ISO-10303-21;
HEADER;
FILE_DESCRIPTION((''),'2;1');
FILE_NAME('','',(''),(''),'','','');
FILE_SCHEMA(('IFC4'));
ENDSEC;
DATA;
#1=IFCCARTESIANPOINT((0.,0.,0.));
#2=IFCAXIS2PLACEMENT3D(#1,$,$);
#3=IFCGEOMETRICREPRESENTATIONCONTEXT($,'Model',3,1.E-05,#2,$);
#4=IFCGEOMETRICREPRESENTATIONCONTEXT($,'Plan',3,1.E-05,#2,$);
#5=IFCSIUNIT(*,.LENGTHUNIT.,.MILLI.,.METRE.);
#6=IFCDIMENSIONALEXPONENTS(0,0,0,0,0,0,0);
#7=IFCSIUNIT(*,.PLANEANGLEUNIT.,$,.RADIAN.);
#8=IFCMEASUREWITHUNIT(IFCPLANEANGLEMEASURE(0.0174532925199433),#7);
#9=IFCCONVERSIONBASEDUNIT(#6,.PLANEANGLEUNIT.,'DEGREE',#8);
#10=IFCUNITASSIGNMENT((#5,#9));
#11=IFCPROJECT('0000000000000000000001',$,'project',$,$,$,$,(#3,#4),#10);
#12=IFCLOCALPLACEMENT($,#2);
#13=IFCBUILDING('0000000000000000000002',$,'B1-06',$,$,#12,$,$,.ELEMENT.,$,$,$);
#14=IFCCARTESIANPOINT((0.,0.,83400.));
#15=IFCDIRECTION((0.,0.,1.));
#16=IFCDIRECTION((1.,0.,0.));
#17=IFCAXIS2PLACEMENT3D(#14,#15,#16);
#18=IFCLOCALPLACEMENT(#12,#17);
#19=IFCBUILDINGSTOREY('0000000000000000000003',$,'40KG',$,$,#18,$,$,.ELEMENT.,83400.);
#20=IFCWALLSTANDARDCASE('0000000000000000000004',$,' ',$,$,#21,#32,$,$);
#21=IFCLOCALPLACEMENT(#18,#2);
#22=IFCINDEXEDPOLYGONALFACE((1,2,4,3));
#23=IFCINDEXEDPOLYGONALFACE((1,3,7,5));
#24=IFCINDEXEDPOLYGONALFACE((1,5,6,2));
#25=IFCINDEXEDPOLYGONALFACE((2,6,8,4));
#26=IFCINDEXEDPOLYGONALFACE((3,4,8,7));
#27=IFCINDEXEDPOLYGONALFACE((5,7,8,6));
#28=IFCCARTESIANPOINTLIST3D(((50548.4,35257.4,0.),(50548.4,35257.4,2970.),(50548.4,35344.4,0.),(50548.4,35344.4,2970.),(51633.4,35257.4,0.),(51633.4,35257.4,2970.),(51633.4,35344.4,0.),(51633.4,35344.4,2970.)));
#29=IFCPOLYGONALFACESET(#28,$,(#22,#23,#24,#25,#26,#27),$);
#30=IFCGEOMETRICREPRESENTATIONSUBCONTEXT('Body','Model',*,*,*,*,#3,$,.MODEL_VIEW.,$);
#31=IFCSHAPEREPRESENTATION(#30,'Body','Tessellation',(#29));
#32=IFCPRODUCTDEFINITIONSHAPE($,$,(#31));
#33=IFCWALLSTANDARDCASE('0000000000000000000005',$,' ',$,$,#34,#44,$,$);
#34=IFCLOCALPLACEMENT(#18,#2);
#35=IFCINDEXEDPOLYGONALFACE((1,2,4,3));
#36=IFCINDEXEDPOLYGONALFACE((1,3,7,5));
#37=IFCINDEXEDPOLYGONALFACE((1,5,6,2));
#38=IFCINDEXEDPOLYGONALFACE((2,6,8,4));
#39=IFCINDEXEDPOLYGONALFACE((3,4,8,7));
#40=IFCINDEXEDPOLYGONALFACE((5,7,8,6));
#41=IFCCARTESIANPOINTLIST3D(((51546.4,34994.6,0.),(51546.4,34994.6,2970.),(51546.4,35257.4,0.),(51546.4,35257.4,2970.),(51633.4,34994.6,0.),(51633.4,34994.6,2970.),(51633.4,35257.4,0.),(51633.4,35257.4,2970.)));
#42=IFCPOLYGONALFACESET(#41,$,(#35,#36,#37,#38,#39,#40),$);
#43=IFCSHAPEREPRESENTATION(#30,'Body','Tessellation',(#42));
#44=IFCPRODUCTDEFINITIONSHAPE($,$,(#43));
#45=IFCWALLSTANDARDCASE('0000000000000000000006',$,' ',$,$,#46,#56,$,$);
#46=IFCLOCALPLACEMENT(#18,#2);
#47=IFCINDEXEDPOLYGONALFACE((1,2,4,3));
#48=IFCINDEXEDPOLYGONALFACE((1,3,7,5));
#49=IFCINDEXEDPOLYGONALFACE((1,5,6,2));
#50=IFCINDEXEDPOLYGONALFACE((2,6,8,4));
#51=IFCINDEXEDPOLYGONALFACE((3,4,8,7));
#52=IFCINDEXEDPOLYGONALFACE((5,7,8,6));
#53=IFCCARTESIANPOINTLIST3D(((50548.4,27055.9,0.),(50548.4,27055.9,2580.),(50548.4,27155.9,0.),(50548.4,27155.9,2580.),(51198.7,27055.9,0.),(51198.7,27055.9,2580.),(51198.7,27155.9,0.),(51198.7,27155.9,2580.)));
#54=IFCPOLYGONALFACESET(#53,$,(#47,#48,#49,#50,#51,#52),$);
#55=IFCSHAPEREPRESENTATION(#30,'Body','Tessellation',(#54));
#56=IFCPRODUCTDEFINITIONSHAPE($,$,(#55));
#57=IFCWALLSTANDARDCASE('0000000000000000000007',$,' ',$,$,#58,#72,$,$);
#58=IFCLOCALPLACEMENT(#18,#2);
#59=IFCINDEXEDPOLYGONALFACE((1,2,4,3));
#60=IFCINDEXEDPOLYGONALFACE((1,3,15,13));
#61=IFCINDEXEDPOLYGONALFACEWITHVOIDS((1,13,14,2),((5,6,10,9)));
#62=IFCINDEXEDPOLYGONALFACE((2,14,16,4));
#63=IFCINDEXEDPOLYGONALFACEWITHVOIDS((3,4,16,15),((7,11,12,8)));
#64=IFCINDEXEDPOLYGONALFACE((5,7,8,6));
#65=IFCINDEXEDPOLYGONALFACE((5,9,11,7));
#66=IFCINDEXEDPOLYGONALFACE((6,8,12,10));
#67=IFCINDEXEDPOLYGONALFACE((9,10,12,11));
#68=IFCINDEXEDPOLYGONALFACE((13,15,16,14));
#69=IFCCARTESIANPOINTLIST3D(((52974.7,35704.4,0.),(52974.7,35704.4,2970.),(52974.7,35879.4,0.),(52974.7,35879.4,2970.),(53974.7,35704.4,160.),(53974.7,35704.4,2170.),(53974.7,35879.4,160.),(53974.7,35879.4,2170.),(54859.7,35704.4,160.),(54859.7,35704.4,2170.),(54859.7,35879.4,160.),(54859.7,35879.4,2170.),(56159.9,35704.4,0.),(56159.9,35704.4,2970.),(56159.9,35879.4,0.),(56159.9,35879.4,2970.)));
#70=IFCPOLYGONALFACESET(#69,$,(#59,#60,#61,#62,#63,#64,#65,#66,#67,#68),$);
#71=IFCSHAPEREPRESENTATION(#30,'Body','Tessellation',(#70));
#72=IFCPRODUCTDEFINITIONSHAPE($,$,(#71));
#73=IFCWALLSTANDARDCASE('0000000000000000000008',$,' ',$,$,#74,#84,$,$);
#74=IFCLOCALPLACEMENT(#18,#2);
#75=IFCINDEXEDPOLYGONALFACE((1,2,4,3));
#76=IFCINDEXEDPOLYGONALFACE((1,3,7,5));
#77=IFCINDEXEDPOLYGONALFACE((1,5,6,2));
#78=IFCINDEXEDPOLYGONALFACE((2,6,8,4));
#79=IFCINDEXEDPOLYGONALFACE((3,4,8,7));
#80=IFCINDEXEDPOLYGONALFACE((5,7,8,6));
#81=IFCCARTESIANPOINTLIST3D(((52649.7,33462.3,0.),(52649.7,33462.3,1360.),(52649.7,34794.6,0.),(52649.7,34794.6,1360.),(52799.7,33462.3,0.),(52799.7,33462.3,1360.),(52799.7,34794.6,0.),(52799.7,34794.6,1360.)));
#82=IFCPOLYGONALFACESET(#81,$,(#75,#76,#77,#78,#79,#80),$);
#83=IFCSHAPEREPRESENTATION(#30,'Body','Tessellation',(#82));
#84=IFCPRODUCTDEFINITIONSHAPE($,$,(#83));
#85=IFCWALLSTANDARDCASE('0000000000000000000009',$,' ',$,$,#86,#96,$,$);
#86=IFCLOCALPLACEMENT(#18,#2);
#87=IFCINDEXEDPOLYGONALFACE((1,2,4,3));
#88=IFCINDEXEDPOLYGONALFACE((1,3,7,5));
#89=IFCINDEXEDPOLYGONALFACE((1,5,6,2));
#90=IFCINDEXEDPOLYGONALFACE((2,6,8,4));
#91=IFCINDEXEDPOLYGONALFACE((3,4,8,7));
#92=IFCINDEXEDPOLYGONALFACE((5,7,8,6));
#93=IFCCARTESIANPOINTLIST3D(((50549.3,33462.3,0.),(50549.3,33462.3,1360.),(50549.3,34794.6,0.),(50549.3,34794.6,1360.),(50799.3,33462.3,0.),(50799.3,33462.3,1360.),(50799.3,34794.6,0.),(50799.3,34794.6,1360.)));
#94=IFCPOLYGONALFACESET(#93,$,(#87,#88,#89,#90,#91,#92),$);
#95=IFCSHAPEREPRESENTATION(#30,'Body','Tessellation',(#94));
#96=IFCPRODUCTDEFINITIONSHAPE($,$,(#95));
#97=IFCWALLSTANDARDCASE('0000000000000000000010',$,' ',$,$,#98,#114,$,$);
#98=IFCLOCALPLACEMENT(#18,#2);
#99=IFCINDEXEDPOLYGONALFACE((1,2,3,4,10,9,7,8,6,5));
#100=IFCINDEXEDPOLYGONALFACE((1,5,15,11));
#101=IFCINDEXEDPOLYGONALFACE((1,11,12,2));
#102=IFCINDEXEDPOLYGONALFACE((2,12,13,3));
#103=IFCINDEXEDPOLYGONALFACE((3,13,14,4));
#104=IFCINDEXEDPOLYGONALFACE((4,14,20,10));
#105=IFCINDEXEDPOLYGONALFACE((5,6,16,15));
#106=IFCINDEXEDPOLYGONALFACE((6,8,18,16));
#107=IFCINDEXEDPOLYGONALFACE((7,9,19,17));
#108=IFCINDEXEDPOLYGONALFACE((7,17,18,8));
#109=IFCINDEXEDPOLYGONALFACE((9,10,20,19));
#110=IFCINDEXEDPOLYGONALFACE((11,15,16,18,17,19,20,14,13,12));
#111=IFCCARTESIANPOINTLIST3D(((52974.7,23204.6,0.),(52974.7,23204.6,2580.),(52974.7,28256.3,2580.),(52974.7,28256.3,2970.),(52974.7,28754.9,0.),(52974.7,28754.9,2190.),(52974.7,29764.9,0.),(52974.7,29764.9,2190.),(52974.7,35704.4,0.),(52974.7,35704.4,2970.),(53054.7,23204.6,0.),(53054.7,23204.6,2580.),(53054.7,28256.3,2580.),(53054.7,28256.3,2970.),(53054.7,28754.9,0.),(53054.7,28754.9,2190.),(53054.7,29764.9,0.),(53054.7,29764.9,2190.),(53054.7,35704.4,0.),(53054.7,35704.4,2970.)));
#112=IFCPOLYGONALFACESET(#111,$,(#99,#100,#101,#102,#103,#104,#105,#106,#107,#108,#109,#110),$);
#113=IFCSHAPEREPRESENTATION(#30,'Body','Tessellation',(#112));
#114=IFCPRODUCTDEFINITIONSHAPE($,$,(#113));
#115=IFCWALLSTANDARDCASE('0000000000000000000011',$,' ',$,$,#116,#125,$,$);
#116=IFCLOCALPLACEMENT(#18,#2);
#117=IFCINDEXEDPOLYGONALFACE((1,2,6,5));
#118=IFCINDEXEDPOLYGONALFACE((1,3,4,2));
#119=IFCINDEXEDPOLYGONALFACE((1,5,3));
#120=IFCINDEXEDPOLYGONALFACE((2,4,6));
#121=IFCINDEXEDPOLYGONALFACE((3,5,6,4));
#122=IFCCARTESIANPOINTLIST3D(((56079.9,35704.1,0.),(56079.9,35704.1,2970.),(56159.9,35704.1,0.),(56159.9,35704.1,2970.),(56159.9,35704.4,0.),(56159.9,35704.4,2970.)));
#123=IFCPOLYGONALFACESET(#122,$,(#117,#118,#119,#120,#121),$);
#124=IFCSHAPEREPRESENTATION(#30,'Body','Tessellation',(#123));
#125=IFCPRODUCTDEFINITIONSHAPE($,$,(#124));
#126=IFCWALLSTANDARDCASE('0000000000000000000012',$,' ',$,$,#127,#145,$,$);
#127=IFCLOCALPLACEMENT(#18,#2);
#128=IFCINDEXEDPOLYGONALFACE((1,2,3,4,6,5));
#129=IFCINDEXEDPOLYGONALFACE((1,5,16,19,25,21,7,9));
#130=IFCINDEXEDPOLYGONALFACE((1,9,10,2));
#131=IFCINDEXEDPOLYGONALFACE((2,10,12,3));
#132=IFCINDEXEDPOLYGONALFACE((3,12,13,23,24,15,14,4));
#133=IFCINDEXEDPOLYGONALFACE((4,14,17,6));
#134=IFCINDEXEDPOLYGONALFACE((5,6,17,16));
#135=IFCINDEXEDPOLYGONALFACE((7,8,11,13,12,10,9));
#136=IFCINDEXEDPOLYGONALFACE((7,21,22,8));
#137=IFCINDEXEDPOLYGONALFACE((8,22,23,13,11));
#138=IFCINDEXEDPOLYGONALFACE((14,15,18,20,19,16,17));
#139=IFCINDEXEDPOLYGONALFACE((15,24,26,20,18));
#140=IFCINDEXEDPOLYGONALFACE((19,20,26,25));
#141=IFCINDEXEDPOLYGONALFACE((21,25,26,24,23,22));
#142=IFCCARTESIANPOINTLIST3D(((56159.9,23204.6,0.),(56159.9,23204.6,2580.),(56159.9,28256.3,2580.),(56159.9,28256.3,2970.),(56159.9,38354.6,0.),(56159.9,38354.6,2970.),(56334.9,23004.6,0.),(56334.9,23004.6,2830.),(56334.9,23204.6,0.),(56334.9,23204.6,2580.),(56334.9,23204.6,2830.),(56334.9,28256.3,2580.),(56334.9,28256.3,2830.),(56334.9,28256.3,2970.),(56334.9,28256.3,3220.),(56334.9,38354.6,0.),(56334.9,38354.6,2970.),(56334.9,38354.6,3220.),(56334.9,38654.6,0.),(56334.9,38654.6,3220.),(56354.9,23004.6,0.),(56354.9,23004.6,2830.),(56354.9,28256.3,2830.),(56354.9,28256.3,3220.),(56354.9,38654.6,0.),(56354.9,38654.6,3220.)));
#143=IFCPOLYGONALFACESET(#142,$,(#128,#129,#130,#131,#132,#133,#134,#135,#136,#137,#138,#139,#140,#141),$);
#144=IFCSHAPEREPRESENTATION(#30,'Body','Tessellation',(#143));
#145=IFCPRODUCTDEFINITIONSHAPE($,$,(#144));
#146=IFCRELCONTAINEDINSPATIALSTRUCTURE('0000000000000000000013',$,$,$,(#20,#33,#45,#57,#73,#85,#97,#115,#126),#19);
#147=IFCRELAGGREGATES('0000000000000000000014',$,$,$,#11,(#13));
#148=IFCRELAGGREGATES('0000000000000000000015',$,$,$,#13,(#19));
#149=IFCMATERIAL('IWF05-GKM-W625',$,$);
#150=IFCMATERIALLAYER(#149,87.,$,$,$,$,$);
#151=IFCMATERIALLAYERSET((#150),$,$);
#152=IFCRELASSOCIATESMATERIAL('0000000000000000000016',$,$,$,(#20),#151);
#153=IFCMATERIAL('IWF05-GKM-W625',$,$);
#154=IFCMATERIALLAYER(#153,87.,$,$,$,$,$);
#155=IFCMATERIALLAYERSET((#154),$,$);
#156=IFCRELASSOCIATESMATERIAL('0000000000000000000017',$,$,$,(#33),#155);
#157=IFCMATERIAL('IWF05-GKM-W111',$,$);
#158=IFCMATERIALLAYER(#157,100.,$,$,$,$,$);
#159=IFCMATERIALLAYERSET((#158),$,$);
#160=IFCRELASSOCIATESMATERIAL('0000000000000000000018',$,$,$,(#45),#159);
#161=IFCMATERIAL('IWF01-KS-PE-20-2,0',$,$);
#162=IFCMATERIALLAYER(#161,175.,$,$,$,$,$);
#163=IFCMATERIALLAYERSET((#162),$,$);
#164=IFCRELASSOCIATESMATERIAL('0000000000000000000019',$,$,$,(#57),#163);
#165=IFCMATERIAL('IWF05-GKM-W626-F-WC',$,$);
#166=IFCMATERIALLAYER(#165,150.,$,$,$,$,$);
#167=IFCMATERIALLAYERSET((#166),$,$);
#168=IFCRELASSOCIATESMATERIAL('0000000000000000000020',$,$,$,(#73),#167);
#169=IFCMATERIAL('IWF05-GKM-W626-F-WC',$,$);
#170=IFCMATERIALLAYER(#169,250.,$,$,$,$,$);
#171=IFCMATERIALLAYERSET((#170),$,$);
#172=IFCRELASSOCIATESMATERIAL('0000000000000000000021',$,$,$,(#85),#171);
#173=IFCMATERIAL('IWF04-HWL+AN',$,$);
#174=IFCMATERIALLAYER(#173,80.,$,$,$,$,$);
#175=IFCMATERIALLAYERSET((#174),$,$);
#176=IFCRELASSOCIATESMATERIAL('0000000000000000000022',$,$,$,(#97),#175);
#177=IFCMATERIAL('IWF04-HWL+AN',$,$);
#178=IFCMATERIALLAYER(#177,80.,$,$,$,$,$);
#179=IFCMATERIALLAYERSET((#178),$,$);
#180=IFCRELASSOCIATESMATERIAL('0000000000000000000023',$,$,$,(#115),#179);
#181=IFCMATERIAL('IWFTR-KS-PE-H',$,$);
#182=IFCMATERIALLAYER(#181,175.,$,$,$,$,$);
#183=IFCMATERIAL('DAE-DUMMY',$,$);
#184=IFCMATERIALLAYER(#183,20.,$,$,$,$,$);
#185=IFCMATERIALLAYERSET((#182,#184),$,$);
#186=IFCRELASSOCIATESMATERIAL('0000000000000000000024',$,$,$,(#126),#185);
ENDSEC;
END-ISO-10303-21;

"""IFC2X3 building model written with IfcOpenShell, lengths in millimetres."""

from ifc_helpers import new_model, entity, si_unit, converted_unit, frame, frame_2d, origin, origin_with_axes, place, context, subcontext, project, spatial, polyline, rectangle, outline, extrude, clip, bounded_halfspace, material, layer, layer_set, layer_usage, element, save


model = new_model("IFC2X3")

# Units and contexts
model_context = context("Model", 3, precision=1e-05, world=origin())
plan_context = context("Plan", 3, precision=1e-05, world=origin())
body_context = subcontext(model_context, "Body", "Model", "MODEL_VIEW")
ifc_project = project(units=[si_unit("LENGTHUNIT", "METRE", prefix="MILLI"), converted_unit("PLANEANGLEUNIT", "DEGREE", entity("IfcPlaneAngleMeasure", 0.0174532925199433), si_unit("PLANEANGLEUNIT", "RADIAN"), dimensions=[0, 0, 0, 0, 0, 0, 0])], contexts=[model_context, plan_context])

# Building, storey
building_placement = place(None, origin())
building = spatial("IfcBuilding", under=ifc_project, at=building_placement, Name="B1-06", CompositionType="ELEMENT")
storey_placement = place(building_placement, frame((0.0, 0.0, 83400.0), z_axis=(0.0, 0.0, 1.0), x_axis=(1.0, 0.0, 0.0)))
storey = spatial("IfcBuildingStorey", under=building, at=storey_placement, Name="40KG", CompositionType="ELEMENT", Elevation=83400.0)

# Walls
ifc_material_1 = material(Name="IWF05-GKM-W625")
ifc_layer_1 = layer(ifc_material_1, 87.0)
ifc_layer_set_1 = layer_set([ifc_layer_1])
ifc_layer_usage_1 = layer_usage(ifc_layer_set_1, "AXIS2", "POSITIVE", 0.0)
wall_1_placement = place(storey_placement, frame((51633.4, 35344.4, 0.0), z_axis=(0.0, 0.0, 1.0), x_axis=(-1.0, 0.0, 0.0)))
element("IfcWallStandardCase", 1, at=wall_1_placement, inside=storey, material=ifc_layer_usage_1, Name=" ", context=body_context, shape_type="SweptSolid", body=[
    extrude(rectangle(XDim=1085.0, YDim=87.0, at=frame_2d((542.5, 43.5), x_axis=(1.0, 0.0))), origin_with_axes(), (0.0, 0.0, 1.0), 2970.0),
])
ifc_material_2 = material(Name="IWF05-GKM-W625")
ifc_layer_2 = layer(ifc_material_2, 87.0)
ifc_layer_set_2 = layer_set([ifc_layer_2])
ifc_layer_usage_2 = layer_usage(ifc_layer_set_2, "AXIS2", "POSITIVE", 0.0)
wall_2_placement = place(storey_placement, frame((51633.4, 34994.6, 0.0), z_axis=(0.0, 0.0, 1.0), x_axis=(0.0, 1.0, 0.0)))
element("IfcWallStandardCase", 2, at=wall_2_placement, inside=storey, material=ifc_layer_usage_2, Name=" ", context=body_context, shape_type="SweptSolid", body=[
    extrude(rectangle(XDim=262.8, YDim=87.0, at=frame_2d((131.4, 43.5), x_axis=(1.0, 0.0))), origin_with_axes(), (0.0, 0.0, 1.0), 2970.0),
])
ifc_material_3 = material(Name="IWF05-GKM-W111")
ifc_layer_3 = layer(ifc_material_3, 100.0)
ifc_layer_set_3 = layer_set([ifc_layer_3])
ifc_layer_usage_3 = layer_usage(ifc_layer_set_3, "AXIS2", "POSITIVE", 0.0)
wall_3_placement = place(storey_placement, frame((51198.7, 27155.9, 0.0), z_axis=(0.0, 0.0, 1.0), x_axis=(-1.0, 0.0, 0.0)))
element("IfcWallStandardCase", 3, at=wall_3_placement, inside=storey, material=ifc_layer_usage_3, Name=" ", context=body_context, shape_type="SweptSolid", body=[
    extrude(rectangle(XDim=650.3, YDim=100.0, at=frame_2d((325.2, 50.0), x_axis=(1.0, 0.0))), origin_with_axes(), (0.0, 0.0, 1.0), 2580.0),
])

# Wall, opening
ifc_material_4 = material(Name="IWF01-KS-PE-20-2,0")
ifc_layer_4 = layer(ifc_material_4, 175.0)
ifc_layer_set_4 = layer_set([ifc_layer_4])
ifc_layer_usage_4 = layer_usage(ifc_layer_set_4, "AXIS2", "POSITIVE", 0.0)
wall_4_placement = place(storey_placement, frame((56159.9, 35879.4, 0.0), z_axis=(0.0, 0.0, 1.0), x_axis=(-1.0, 0.0, 0.0)))
wall_4 = element("IfcWallStandardCase", 4, at=wall_4_placement, inside=storey, material=ifc_layer_usage_4, Name=" ", context=body_context, shape_type="SweptSolid", body=[
    extrude(rectangle(XDim=3185.2, YDim=175.0, at=frame_2d((1592.6, 87.5), x_axis=(1.0, 0.0))), origin_with_axes(), (0.0, 0.0, 1.0), 2970.0),
])
opening_1_placement = place(wall_4_placement, frame((1300.1, 0.0, 160.0), z_axis=(0.0, 1.0, 0.0), x_axis=(0.0, 0.0, 1.0)))
element("IfcOpeningElement", 5, at=opening_1_placement, cuts=wall_4, ObjectType="Opening", context=body_context, shape_type="SweptSolid", body=[
    extrude(rectangle(XDim=2010.0, YDim=885.0, at=frame_2d((1005.0, 442.5), x_axis=(1.0, 0.0))), origin_with_axes(), (0.0, 0.0, 1.0), 175.0),
])

# Walls
ifc_material_5 = material(Name="IWF05-GKM-W626-F-WC")
ifc_layer_5 = layer(ifc_material_5, 150.0)
ifc_layer_set_5 = layer_set([ifc_layer_5])
ifc_layer_usage_5 = layer_usage(ifc_layer_set_5, "AXIS2", "POSITIVE", 0.0)
wall_5_placement = place(storey_placement, frame((52799.7, 33462.3, 0.0), z_axis=(0.0, 0.0, 1.0), x_axis=(0.0, 1.0, 0.0)))
element("IfcWallStandardCase", 6, at=wall_5_placement, inside=storey, material=ifc_layer_usage_5, Name=" ", context=body_context, shape_type="SweptSolid", body=[
    extrude(rectangle(XDim=1332.2, YDim=150.0, at=frame_2d((666.1, 75.0), x_axis=(1.0, 0.0))), origin_with_axes(), (0.0, 0.0, 1.0), 1360.0),
])
ifc_material_6 = material(Name="IWF05-GKM-W626-F-WC")
ifc_layer_6 = layer(ifc_material_6, 250.0)
ifc_layer_set_6 = layer_set([ifc_layer_6])
ifc_layer_usage_6 = layer_usage(ifc_layer_set_6, "AXIS2", "POSITIVE", 0.0)
wall_6_placement = place(storey_placement, frame((50549.3, 34794.6, 0.0), z_axis=(0.0, 0.0, 1.0), x_axis=(0.0, -1.0, 0.0)))
element("IfcWallStandardCase", 7, at=wall_6_placement, inside=storey, material=ifc_layer_usage_6, Name=" ", context=body_context, shape_type="SweptSolid", body=[
    extrude(rectangle(XDim=1332.2, YDim=250.0, at=frame_2d((666.1, 125.0), x_axis=(1.0, 0.0))), origin_with_axes(), (0.0, 0.0, 1.0), 1360.0),
])

# Wall, opening
ifc_material_7 = material(Name="IWF04-HWL+AN")
ifc_layer_7 = layer(ifc_material_7, 80.0)
ifc_layer_set_7 = layer_set([ifc_layer_7])
ifc_layer_usage_7 = layer_usage(ifc_layer_set_7, "AXIS2", "POSITIVE", 0.0)
wall_7_placement = place(storey_placement, frame((52974.7, 35704.4, 0.0), z_axis=(0.0, 0.0, 1.0), x_axis=(0.0, -1.0, 0.0)))
wall_7 = element("IfcWallStandardCase", 8, at=wall_7_placement, inside=storey, material=ifc_layer_usage_7, Name=" ", context=body_context, shape_type="Clipping", body=[
    clip(clip(extrude(outline(polyline([(0.0, 0.0), (12499.8, 0.0), (12499.8, 80.0), (0.0, 80.0), (0.0, 0.0)])), origin_with_axes(), (0.0, 0.0, 1.0), 2970.0), bounded_halfspace(frame((7448.1, 0.0, 2580.0), z_axis=(0.0, 0.0, -1.0), x_axis=(1.0, 0.0, 0.0)), True, origin(), polyline([(7448.1, 0.0), (12499.8, 0.0), (12499.8, 80.0), (7448.1, 80.0), (7448.1, 0.0)]))), bounded_halfspace(frame((7448.1, 0.0, 2970.0), z_axis=(0.0, 0.0, -1.0), x_axis=(0.0, 1.0, 0.0)), True, origin(), polyline([(7448.1, 0.0), (7448.1, 80.0), (0.0, 80.0), (0.0, 0.0), (7448.1, 0.0)]))),
])
opening_2_placement = place(wall_7_placement, frame((5939.5, 0.0, 0.0), z_axis=(0.0, 1.0, 0.0), x_axis=(0.0, 0.0, 1.0)))
element("IfcOpeningElement", 9, at=opening_2_placement, cuts=wall_7, ObjectType="Opening", context=body_context, shape_type="SweptSolid", body=[
    extrude(rectangle(XDim=2190.0, YDim=1010.0, at=frame_2d((1095.0, 505.0), x_axis=(1.0, 0.0))), origin_with_axes(), (0.0, 0.0, 1.0), 80.0),
])

# Walls
ifc_material_8 = material(Name="IWF04-HWL+AN")
ifc_layer_8 = layer(ifc_material_8, 80.0)
ifc_layer_set_8 = layer_set([ifc_layer_8])
ifc_layer_usage_8 = layer_usage(ifc_layer_set_8, "AXIS2", "POSITIVE", 0.0)
wall_8_placement = place(storey_placement, frame((56159.9, 35704.4, 0.0), z_axis=(0.0, 0.0, 1.0), x_axis=(-1.0, 0.0, 0.0)))
element("IfcWallStandardCase", 10, at=wall_8_placement, inside=storey, material=ifc_layer_usage_8, Name=" ", context=body_context, shape_type="SweptSolid", body=[
    extrude(outline(polyline([(0.0, 0.0), (80.0, 0.2), (0.0, 0.2), (0.0, 0.0)])), origin_with_axes(), (0.0, 0.0, 1.0), 2970.0),
])
ifc_material_9 = material(Name="IWFTR-KS-PE-H")
ifc_layer_9 = layer(ifc_material_9, 175.0)
ifc_material_10 = material(Name="DAE-DUMMY")
ifc_layer_10 = layer(ifc_material_10, 20.0)
ifc_layer_set_9 = layer_set([ifc_layer_9, ifc_layer_10])
ifc_layer_usage_9 = layer_usage(ifc_layer_set_9, "AXIS2", "POSITIVE", 0.0)
wall_9_placement = place(storey_placement, frame((56159.9, 38354.6, 0.0), z_axis=(0.0, 0.0, 1.0), x_axis=(0.0, -1.0, 0.0)))
element("IfcWallStandardCase", 11, at=wall_9_placement, inside=storey, material=ifc_layer_usage_9, Name=" ", context=body_context, shape_type="Clipping", body=[
    clip(clip(clip(clip(extrude(outline(polyline([(0.0, 0.0), (15150.0, 0.0), (15150.0, 175.0), (15350.0, 175.0), (15350.0, 195.0), (-300.0, 195.0), (-300.0, 175.0), (0.0, 175.0), (0.0, 0.0)])), origin_with_axes(), (0.0, 0.0, 1.0), 3220.0), bounded_halfspace(frame((10098.3, 0.0, 2580.0), z_axis=(0.0, 0.0, -1.0), x_axis=(1.0, 0.0, 0.0)), True, origin(), polyline([(10098.3, 0.0), (15150.0, 0.0), (15150.0, 175.0), (10098.3, 175.0), (10098.3, 0.0)]))), bounded_halfspace(frame((10098.3, 0.0, 2970.0), z_axis=(0.0, 0.0, -1.0), x_axis=(0.0, 1.0, 0.0)), True, origin(), polyline([(10098.3, 0.0), (10098.3, 175.0), (0.0, 175.0), (0.0, 0.0), (10098.3, 0.0)]))), bounded_halfspace(frame((15350.0, 175.0, 2830.0), z_axis=(0.0, 0.0, -1.0), x_axis=(0.0, 1.0, 0.0)), True, origin(), polyline([(15350.0, 175.0), (15350.0, 195.0), (10098.3, 195.0), (10098.3, 175.0), (15350.0, 175.0)]))), bounded_halfspace(frame((10098.3, 175.0, 3220.0), z_axis=(0.0, 0.0, -1.0), x_axis=(0.0, 1.0, 0.0)), True, origin(), polyline([(10098.3, 175.0), (10098.3, 195.0), (-300.0, 195.0), (-300.0, 175.0), (10098.3, 175.0)]))),
])

save(model, "model.ifc")
